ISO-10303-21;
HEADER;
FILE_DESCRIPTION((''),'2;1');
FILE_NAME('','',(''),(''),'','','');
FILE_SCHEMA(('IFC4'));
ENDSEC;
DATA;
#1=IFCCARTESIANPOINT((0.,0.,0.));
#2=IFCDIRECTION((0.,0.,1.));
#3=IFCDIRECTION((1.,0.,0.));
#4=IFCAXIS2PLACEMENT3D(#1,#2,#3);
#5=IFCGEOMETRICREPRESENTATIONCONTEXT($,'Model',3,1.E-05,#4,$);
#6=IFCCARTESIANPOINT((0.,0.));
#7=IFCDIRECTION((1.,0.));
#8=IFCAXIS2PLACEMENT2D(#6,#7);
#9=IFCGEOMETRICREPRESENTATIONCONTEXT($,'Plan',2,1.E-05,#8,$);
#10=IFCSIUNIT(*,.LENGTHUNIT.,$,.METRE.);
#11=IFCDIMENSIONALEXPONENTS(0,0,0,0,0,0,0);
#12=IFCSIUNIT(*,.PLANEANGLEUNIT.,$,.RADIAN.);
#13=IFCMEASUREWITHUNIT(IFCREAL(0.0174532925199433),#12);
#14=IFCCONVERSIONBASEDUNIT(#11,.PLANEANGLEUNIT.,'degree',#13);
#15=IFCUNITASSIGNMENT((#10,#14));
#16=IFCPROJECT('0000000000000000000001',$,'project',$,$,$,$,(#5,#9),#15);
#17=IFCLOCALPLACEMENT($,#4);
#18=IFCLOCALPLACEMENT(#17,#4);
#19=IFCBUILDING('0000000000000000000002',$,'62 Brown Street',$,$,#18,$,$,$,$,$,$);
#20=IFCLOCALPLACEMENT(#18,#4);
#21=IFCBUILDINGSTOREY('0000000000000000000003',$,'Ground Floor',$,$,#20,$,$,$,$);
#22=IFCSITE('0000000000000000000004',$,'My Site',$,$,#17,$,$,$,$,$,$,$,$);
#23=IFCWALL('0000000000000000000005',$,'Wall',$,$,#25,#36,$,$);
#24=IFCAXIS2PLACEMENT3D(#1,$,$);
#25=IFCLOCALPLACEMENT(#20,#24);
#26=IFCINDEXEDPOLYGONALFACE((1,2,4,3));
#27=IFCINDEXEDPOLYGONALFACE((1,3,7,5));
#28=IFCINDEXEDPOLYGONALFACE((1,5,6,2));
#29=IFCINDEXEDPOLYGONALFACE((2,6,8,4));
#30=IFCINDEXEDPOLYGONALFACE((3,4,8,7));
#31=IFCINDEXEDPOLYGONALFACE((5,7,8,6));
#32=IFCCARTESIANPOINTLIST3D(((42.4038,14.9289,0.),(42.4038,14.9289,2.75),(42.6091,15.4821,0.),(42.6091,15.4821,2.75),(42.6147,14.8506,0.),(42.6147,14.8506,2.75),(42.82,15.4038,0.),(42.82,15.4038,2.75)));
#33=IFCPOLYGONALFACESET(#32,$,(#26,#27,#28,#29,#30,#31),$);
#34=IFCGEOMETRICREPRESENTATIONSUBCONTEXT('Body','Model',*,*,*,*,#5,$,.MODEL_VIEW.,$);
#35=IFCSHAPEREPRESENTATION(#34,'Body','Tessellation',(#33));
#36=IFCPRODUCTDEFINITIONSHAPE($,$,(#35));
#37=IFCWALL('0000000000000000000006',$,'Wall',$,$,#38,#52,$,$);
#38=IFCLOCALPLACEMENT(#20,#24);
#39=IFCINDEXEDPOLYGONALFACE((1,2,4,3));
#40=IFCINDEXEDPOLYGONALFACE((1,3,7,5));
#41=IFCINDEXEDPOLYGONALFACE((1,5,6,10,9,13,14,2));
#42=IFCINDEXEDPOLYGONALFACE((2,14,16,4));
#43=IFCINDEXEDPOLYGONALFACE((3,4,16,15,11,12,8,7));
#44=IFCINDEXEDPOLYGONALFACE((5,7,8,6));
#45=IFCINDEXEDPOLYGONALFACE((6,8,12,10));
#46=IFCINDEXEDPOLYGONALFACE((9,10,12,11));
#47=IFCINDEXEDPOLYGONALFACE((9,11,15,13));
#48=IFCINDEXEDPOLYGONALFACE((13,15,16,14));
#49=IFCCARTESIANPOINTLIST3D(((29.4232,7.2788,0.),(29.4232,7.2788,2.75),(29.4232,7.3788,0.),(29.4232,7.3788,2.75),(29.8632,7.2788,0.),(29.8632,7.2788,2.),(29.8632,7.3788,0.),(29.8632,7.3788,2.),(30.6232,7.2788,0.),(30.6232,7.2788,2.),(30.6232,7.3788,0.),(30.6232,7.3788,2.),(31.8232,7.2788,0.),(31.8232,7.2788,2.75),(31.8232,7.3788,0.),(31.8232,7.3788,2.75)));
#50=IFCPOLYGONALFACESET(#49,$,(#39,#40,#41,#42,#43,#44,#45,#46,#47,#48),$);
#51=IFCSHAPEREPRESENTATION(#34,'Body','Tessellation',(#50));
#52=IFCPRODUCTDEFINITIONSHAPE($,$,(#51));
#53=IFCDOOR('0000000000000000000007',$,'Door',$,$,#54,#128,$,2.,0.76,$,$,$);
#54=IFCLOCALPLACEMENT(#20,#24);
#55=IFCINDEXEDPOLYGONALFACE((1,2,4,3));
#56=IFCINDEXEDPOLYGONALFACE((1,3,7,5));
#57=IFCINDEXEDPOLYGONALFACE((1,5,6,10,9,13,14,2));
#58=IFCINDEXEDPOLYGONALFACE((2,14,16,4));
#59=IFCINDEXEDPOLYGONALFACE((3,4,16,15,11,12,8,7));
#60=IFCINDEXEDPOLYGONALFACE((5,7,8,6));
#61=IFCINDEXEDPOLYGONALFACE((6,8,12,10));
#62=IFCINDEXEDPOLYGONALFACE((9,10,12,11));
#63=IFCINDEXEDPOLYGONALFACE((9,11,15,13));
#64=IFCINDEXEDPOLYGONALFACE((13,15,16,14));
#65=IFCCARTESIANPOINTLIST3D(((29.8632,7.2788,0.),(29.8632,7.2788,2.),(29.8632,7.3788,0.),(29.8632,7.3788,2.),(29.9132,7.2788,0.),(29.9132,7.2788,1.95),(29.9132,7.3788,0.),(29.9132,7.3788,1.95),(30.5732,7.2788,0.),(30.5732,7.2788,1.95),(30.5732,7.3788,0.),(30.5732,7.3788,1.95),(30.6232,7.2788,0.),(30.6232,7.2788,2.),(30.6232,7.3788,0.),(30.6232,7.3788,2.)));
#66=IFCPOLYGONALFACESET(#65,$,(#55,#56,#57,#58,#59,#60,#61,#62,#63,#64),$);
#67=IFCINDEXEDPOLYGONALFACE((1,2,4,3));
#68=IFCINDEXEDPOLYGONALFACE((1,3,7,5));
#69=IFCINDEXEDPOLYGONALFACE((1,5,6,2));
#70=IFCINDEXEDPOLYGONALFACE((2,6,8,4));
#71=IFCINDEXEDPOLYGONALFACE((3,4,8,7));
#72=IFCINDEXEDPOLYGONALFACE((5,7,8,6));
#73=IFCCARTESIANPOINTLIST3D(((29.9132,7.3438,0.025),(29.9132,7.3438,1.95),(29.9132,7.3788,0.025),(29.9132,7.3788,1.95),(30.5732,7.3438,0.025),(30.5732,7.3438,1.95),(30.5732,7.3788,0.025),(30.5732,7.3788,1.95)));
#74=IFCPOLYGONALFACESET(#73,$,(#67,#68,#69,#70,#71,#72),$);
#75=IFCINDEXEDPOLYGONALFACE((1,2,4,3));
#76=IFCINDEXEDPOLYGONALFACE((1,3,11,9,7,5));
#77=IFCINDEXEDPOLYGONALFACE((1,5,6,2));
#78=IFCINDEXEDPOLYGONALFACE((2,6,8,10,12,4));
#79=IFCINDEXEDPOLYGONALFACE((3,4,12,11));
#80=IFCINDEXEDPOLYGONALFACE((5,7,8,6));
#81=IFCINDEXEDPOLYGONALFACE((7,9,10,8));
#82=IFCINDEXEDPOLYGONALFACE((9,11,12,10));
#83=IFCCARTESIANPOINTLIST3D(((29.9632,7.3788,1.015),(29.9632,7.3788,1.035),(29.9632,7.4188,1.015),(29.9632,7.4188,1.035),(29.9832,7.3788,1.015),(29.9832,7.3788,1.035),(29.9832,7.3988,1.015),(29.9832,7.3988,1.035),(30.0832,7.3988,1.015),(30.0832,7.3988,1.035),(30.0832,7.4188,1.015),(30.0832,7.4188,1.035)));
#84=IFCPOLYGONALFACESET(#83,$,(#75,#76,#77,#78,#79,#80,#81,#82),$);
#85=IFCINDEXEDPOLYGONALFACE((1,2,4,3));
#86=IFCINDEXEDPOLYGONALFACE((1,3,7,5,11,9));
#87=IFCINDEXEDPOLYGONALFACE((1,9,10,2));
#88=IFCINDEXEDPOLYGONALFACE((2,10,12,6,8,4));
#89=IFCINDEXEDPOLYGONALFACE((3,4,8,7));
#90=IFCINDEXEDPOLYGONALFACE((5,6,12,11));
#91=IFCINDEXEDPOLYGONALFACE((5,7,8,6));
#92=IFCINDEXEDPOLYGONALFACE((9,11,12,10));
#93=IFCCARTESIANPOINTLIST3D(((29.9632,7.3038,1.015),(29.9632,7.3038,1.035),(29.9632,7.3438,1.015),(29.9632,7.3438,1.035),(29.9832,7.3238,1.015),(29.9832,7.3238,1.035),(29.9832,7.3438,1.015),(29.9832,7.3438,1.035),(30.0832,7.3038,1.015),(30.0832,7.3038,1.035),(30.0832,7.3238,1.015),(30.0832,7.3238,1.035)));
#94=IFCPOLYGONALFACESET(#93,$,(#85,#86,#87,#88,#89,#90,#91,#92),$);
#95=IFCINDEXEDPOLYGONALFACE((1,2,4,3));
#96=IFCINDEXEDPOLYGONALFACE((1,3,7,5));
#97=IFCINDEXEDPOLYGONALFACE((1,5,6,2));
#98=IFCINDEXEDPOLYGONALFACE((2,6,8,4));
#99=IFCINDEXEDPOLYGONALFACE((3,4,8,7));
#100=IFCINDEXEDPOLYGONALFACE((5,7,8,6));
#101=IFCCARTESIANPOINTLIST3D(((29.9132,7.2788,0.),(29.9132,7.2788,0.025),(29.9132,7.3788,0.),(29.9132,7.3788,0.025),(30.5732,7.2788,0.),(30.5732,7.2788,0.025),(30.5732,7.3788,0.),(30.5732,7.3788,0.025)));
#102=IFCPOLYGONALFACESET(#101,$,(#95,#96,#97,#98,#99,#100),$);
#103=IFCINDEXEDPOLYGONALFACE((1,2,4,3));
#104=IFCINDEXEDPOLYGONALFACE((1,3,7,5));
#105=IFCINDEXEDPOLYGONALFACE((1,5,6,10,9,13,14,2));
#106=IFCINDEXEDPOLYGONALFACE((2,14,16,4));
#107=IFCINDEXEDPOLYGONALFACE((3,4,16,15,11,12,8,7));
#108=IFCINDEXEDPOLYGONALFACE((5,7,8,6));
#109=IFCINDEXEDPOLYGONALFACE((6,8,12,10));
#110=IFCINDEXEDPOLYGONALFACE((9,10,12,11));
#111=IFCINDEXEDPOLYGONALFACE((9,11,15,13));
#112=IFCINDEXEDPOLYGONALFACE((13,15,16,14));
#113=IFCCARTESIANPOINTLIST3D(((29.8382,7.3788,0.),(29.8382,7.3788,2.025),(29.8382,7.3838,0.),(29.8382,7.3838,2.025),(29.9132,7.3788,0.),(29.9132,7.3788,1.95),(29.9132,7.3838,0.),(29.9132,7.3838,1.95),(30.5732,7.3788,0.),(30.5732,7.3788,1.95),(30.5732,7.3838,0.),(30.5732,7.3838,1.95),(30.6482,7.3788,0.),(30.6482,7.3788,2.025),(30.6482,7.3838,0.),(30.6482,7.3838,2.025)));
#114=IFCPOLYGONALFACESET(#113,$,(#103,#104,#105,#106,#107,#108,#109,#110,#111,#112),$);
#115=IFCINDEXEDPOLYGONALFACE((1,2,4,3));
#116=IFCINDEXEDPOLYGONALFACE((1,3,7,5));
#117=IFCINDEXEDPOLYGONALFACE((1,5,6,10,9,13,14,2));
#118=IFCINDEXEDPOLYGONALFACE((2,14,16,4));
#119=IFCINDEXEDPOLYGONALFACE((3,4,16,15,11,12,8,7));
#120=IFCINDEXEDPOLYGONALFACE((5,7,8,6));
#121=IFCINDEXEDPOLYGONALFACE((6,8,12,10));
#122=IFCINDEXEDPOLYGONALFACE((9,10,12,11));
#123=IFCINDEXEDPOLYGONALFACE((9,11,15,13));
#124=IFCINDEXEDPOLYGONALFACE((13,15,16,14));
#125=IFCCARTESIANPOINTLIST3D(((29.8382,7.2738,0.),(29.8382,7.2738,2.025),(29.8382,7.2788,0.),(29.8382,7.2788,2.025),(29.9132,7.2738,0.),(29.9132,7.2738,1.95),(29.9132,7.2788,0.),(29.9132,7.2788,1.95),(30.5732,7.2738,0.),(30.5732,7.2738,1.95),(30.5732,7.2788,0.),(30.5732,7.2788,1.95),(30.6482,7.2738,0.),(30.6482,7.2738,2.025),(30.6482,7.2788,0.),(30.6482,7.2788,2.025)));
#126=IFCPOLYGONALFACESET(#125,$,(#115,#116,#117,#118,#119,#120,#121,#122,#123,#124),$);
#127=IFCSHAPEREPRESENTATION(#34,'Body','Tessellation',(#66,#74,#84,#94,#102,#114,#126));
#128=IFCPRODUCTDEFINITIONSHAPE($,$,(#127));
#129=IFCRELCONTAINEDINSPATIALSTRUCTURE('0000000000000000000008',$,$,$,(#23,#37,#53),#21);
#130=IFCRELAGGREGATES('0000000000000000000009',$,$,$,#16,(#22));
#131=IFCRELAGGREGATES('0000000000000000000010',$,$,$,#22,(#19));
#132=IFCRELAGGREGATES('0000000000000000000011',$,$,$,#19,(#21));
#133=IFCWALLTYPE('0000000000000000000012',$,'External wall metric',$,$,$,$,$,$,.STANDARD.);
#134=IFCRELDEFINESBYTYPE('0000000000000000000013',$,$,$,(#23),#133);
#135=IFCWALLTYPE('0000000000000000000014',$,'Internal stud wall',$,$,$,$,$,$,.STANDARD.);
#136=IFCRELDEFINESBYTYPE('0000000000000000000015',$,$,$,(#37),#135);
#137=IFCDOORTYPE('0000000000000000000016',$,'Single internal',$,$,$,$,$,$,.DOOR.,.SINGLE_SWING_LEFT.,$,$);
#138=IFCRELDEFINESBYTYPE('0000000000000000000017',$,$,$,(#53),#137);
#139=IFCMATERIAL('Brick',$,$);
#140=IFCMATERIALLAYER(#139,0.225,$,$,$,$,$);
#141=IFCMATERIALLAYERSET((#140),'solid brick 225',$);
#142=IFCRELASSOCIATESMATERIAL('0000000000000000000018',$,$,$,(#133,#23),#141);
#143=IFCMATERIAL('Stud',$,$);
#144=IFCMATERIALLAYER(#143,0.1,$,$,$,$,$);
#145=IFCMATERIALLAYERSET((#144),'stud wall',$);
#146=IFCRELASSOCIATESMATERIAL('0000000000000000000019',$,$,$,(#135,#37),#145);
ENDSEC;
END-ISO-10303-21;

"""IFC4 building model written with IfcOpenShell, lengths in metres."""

from ifc_helpers import new_model, entity, si_unit, converted_unit, frame, origin_with_axes, origin_2d_with_axis, place, context, subcontext, project, spatial, line, indexed_curve, outline, extrude, shape, source, transform, mapped, material, layer, layer_set, layer_usage, type_object, type_shapes, element, fill, save


model = new_model("IFC4")

# Units and contexts
model_context = context("Model", 3, precision=1e-05, world=origin_with_axes())
plan_context = context("Plan", 2, precision=1e-05, world=origin_2d_with_axis())
body_context_1 = subcontext(model_context, "Body", "Model", "MODEL_VIEW")
body_context_2 = subcontext(plan_context, "Body", "Plan", "PLAN_VIEW")
ifc_project = project(units=[si_unit("LENGTHUNIT", "METRE"), converted_unit("PLANEANGLEUNIT", "degree", entity("IfcReal", 0.0174532925199433), si_unit("PLANEANGLEUNIT", "RADIAN"), dimensions=[0, 0, 0, 0, 0, 0, 0])], contexts=[model_context, plan_context])

# Site, building, storey
site_placement = place(None, origin_with_axes())
site = spatial("IfcSite", under=ifc_project, at=site_placement, Name="My Site")
building_placement = place(site_placement, origin_with_axes())
building = spatial("IfcBuilding", under=site, at=building_placement, Name="62 Brown Street")
storey_placement = place(building_placement, origin_with_axes())
storey = spatial("IfcBuildingStorey", under=building, at=storey_placement, Name="Ground Floor")

# Shared definitions
ifc_material_1 = material(Name="Brick")
ifc_layer_1 = layer(ifc_material_1, 0.225)
ifc_layer_set_1 = layer_set([ifc_layer_1], Name="solid brick 225")
wall_type_1 = type_object("IfcWallType", Name="External wall metric", PredefinedType="STANDARD", material=ifc_layer_set_1)

# Wall
ifc_layer_usage_1 = layer_usage(ifc_layer_set_1, "AXIS2", "POSITIVE", 0.0)
wall_1_placement = place(storey_placement, frame((42.6147, 14.8506, 0.0), z_axis=(0.0, 0.0, 1.0), x_axis=(0.347944, 0.937515, 0.0)))
element("IfcWall", 1, at=wall_1_placement, inside=storey, type_object=wall_type_1, material=ifc_layer_usage_1, Name="Wall", context=body_context_1, shape_type="SweptSolid", body=[
    extrude(outline(indexed_curve([(0.0, 0.0), (0.0, 0.225), (0.5901, 0.225), (0.5901, 0.0), (0.0, 0.0)], self_intersect=False)), origin_with_axes(), (0.0, 0.0, 1.0), 2.75),
])

# Wall, opening, door
ifc_material_2 = material(Name="Stud")
ifc_layer_2 = layer(ifc_material_2, 0.1)
ifc_layer_set_2 = layer_set([ifc_layer_2], Name="stud wall")
ifc_layer_usage_2 = layer_usage(ifc_layer_set_2, "AXIS2", "POSITIVE", 0.0)
wall_type_2 = type_object("IfcWallType", Name="Internal stud wall", PredefinedType="STANDARD", material=ifc_layer_set_2)
wall_2_placement = place(storey_placement, frame((31.8232, 7.3788, 0.0), z_axis=(0.0, 0.0, 1.0), x_axis=(-1.0, 0.0, 0.0)))
wall_2 = element("IfcWall", 2, at=wall_2_placement, inside=storey, type_object=wall_type_2, material=ifc_layer_usage_2, Name="Wall", context=body_context_1, shape_type="SweptSolid", body=[
    extrude(outline(indexed_curve([(0.0, 0.0), (0.0, 0.1), (2.4, 0.1), (2.4, 0.0), (0.0, 0.0)], self_intersect=False)), origin_with_axes(), (0.0, 0.0, 1.0), 2.75),
])
shared_shape_1 = source(origin_with_axes(), body_context_1, "Body", "SweptSolid", [
    extrude(outline(indexed_curve([(0.0, 0.0), (0.76, 0.0), (0.76, 2.0), (0.0, 2.0)], segments=[line(1, 2, 3, 4, 1)])), frame((0.0, -0.6, 0.0), z_axis=(0.0, -1.0, 0.0), x_axis=(1.0, 0.0, 0.0)), (0.0, 0.0, -1.0), 1.2),
])
opening_1_placement = place(wall_2_placement, frame((1.2, 0.0, 0.0), z_axis=(0.0, 0.0, 1.0), x_axis=(1.0, 0.0, 0.0)))
opening_1 = element("IfcOpeningElement", 3, at=opening_1_placement, cuts=wall_2, PredefinedType="OPENING", context=body_context_1, shape_type="MappedRepresentation", body=[
    mapped(shared_shape_1, transform((0.0, 0.0, 0.0), x_axis=(1.0, 0.0, 0.0), y_axis=(0.0, 1.0, 0.0), z_axis=(0.0, 0.0, 1.0), scale=1.0)),
])
door_type_1 = type_object("IfcDoorType", Name="Single internal", OperationType="SINGLE_SWING_LEFT", PredefinedType="DOOR")
shared_shape_2 = source(origin_with_axes(), body_context_1, "Body", "SweptSolid", [
    extrude(outline(indexed_curve([(0.0, 0.0), (0.0, 2.0), (0.76, 2.0), (0.76, 0.0), (0.71, 0.0), (0.71, 1.95), (0.05, 1.95), (0.05, 0.0)], segments=[line(1, 2, 3, 4, 5, 6, 7, 8, 1)])), frame((0.0, 0.0, 0.0), z_axis=(0.0, -1.0, 0.0), x_axis=(1.0, 0.0, 0.0)), (0.0, 0.0, -1.0), 0.1),
    extrude(outline(indexed_curve([(0.0, 0.0), (0.66, 0.0), (0.66, 0.035), (0.0, 0.035)], segments=[line(1, 2, 3, 4, 1)])), frame((0.05, 0.0, 0.025), z_axis=(0.0, 0.0, 1.0), x_axis=(1.0, 0.0, 0.0)), (0.0, 0.0, 1.0), 1.925),
    extrude(outline(indexed_curve([(0.0, 0.0), (0.0, -0.04), (-0.12, -0.04), (-0.12, -0.02), (-0.02, -0.02), (-0.02, 0.0)], segments=[line(1, 2, 3, 4, 5, 6, 1)])), frame((0.66, 0.0, 1.015), z_axis=(0.0, 0.0, 1.0), x_axis=(1.0, 0.0, 0.0)), (0.0, 0.0, 1.0), 0.02),
    extrude(outline(indexed_curve([(0.0, 0.0), (0.0, 0.04), (-0.12, 0.04), (-0.12, 0.02), (-0.02, 0.02), (-0.02, 0.0)], segments=[line(1, 2, 3, 4, 5, 6, 1)])), frame((0.66, 0.035, 1.015), z_axis=(0.0, 0.0, 1.0), x_axis=(1.0, 0.0, 0.0)), (0.0, 0.0, 1.0), 0.02),
    extrude(outline(indexed_curve([(0.0, 0.0), (0.66, 0.0), (0.66, 0.1), (0.0, 0.1)], segments=[line(1, 2, 3, 4, 1)])), frame((0.05, 0.0, 0.0), z_axis=(0.0, 0.0, 1.0), x_axis=(1.0, 0.0, 0.0)), (0.0, 0.0, 1.0), 0.025),
    extrude(outline(indexed_curve([(0.0, 0.0), (0.0, 2.025), (0.81, 2.025), (0.81, 0.0), (0.735, 0.0), (0.735, 1.95), (0.075, 1.95), (0.075, 0.0)], segments=[line(1, 2, 3, 4, 5, 6, 7, 8, 1)])), frame((-0.025, -0.005, 0.0), z_axis=(0.0, -1.0, 0.0), x_axis=(1.0, 0.0, 0.0)), (0.0, 0.0, -1.0), 0.005),
    extrude(outline(indexed_curve([(0.0, 0.0), (0.0, 2.025), (0.81, 2.025), (0.81, 0.0), (0.735, 0.0), (0.735, 1.95), (0.075, 1.95), (0.075, 0.0)], segments=[line(1, 2, 3, 4, 5, 6, 7, 8, 1)])), frame((-0.025, 0.1, 0.0), z_axis=(0.0, -1.0, 0.0), x_axis=(1.0, 0.0, 0.0)), (0.0, 0.0, -1.0), 0.005),
])
shared_shape_3 = source(origin_with_axes(), body_context_2, "Body", "Curve2D", [
    entity("IfcIndexedPolyCurve", entity("IfcCartesianPointList2D", [[0.0, 0.0], [0.05, 0.0], [0.05, 0.1], [0.0, 0.1]]), [entity("IfcLineIndex", [1, 2, 3, 4, 1])]),
    entity("IfcIndexedPolyCurve", entity("IfcCartesianPointList2D", [[0.76, 0.0], [0.71, 0.0], [0.71, 0.1], [0.76, 0.1]]), [entity("IfcLineIndex", [1, 2, 3, 4, 1])]),
    entity("IfcTrimmedCurve", entity("IfcEllipse", entity("IfcAxis2Placement2D", entity("IfcCartesianPoint", [0.085, 0.1]), entity("IfcDirection", [1.0, 0.0])), 0.625, 0.66), [entity("IfcCartesianPoint", [0.71, 0.1])], [entity("IfcCartesianPoint", [0.085, 0.76])], True, "CARTESIAN"),
    entity("IfcIndexedPolyCurve", entity("IfcCartesianPointList2D", [[0.05, 0.1], [0.085, 0.1], [0.085, 0.76], [0.05, 0.76]]), [entity("IfcLineIndex", [1, 2, 3, 4, 1])]),
])
type_shapes(door_type_1, [shared_shape_2, shared_shape_3])
door_1_placement = place(opening_1_placement, frame((0.0, 0.0, 0.0), z_axis=(0.0, 0.0, 1.0), x_axis=(1.0, 0.0, 0.0)))
door_1 = element("IfcDoor", 4, at=door_1_placement, inside=storey, type_object=door_type_1, Name="Door", OverallHeight=2.0, OverallWidth=0.76, shapes=[
    shape(body_context_1, "Body", "MappedRepresentation", [mapped(shared_shape_2, transform((0.0, 0.0, 0.0), x_axis=(1.0, 0.0, 0.0), y_axis=(0.0, 1.0, 0.0), z_axis=(0.0, 0.0, 1.0), scale=1.0))]),
    shape(body_context_2, "Body", "MappedRepresentation", [mapped(shared_shape_3, transform((0.0, 0.0, 0.0), x_axis=(1.0, 0.0, 0.0), y_axis=(0.0, 1.0, 0.0), z_axis=(0.0, 0.0, 1.0), scale=1.0))]),
])
fill(opening_1, door_1)

save(model, "model.ifc")
